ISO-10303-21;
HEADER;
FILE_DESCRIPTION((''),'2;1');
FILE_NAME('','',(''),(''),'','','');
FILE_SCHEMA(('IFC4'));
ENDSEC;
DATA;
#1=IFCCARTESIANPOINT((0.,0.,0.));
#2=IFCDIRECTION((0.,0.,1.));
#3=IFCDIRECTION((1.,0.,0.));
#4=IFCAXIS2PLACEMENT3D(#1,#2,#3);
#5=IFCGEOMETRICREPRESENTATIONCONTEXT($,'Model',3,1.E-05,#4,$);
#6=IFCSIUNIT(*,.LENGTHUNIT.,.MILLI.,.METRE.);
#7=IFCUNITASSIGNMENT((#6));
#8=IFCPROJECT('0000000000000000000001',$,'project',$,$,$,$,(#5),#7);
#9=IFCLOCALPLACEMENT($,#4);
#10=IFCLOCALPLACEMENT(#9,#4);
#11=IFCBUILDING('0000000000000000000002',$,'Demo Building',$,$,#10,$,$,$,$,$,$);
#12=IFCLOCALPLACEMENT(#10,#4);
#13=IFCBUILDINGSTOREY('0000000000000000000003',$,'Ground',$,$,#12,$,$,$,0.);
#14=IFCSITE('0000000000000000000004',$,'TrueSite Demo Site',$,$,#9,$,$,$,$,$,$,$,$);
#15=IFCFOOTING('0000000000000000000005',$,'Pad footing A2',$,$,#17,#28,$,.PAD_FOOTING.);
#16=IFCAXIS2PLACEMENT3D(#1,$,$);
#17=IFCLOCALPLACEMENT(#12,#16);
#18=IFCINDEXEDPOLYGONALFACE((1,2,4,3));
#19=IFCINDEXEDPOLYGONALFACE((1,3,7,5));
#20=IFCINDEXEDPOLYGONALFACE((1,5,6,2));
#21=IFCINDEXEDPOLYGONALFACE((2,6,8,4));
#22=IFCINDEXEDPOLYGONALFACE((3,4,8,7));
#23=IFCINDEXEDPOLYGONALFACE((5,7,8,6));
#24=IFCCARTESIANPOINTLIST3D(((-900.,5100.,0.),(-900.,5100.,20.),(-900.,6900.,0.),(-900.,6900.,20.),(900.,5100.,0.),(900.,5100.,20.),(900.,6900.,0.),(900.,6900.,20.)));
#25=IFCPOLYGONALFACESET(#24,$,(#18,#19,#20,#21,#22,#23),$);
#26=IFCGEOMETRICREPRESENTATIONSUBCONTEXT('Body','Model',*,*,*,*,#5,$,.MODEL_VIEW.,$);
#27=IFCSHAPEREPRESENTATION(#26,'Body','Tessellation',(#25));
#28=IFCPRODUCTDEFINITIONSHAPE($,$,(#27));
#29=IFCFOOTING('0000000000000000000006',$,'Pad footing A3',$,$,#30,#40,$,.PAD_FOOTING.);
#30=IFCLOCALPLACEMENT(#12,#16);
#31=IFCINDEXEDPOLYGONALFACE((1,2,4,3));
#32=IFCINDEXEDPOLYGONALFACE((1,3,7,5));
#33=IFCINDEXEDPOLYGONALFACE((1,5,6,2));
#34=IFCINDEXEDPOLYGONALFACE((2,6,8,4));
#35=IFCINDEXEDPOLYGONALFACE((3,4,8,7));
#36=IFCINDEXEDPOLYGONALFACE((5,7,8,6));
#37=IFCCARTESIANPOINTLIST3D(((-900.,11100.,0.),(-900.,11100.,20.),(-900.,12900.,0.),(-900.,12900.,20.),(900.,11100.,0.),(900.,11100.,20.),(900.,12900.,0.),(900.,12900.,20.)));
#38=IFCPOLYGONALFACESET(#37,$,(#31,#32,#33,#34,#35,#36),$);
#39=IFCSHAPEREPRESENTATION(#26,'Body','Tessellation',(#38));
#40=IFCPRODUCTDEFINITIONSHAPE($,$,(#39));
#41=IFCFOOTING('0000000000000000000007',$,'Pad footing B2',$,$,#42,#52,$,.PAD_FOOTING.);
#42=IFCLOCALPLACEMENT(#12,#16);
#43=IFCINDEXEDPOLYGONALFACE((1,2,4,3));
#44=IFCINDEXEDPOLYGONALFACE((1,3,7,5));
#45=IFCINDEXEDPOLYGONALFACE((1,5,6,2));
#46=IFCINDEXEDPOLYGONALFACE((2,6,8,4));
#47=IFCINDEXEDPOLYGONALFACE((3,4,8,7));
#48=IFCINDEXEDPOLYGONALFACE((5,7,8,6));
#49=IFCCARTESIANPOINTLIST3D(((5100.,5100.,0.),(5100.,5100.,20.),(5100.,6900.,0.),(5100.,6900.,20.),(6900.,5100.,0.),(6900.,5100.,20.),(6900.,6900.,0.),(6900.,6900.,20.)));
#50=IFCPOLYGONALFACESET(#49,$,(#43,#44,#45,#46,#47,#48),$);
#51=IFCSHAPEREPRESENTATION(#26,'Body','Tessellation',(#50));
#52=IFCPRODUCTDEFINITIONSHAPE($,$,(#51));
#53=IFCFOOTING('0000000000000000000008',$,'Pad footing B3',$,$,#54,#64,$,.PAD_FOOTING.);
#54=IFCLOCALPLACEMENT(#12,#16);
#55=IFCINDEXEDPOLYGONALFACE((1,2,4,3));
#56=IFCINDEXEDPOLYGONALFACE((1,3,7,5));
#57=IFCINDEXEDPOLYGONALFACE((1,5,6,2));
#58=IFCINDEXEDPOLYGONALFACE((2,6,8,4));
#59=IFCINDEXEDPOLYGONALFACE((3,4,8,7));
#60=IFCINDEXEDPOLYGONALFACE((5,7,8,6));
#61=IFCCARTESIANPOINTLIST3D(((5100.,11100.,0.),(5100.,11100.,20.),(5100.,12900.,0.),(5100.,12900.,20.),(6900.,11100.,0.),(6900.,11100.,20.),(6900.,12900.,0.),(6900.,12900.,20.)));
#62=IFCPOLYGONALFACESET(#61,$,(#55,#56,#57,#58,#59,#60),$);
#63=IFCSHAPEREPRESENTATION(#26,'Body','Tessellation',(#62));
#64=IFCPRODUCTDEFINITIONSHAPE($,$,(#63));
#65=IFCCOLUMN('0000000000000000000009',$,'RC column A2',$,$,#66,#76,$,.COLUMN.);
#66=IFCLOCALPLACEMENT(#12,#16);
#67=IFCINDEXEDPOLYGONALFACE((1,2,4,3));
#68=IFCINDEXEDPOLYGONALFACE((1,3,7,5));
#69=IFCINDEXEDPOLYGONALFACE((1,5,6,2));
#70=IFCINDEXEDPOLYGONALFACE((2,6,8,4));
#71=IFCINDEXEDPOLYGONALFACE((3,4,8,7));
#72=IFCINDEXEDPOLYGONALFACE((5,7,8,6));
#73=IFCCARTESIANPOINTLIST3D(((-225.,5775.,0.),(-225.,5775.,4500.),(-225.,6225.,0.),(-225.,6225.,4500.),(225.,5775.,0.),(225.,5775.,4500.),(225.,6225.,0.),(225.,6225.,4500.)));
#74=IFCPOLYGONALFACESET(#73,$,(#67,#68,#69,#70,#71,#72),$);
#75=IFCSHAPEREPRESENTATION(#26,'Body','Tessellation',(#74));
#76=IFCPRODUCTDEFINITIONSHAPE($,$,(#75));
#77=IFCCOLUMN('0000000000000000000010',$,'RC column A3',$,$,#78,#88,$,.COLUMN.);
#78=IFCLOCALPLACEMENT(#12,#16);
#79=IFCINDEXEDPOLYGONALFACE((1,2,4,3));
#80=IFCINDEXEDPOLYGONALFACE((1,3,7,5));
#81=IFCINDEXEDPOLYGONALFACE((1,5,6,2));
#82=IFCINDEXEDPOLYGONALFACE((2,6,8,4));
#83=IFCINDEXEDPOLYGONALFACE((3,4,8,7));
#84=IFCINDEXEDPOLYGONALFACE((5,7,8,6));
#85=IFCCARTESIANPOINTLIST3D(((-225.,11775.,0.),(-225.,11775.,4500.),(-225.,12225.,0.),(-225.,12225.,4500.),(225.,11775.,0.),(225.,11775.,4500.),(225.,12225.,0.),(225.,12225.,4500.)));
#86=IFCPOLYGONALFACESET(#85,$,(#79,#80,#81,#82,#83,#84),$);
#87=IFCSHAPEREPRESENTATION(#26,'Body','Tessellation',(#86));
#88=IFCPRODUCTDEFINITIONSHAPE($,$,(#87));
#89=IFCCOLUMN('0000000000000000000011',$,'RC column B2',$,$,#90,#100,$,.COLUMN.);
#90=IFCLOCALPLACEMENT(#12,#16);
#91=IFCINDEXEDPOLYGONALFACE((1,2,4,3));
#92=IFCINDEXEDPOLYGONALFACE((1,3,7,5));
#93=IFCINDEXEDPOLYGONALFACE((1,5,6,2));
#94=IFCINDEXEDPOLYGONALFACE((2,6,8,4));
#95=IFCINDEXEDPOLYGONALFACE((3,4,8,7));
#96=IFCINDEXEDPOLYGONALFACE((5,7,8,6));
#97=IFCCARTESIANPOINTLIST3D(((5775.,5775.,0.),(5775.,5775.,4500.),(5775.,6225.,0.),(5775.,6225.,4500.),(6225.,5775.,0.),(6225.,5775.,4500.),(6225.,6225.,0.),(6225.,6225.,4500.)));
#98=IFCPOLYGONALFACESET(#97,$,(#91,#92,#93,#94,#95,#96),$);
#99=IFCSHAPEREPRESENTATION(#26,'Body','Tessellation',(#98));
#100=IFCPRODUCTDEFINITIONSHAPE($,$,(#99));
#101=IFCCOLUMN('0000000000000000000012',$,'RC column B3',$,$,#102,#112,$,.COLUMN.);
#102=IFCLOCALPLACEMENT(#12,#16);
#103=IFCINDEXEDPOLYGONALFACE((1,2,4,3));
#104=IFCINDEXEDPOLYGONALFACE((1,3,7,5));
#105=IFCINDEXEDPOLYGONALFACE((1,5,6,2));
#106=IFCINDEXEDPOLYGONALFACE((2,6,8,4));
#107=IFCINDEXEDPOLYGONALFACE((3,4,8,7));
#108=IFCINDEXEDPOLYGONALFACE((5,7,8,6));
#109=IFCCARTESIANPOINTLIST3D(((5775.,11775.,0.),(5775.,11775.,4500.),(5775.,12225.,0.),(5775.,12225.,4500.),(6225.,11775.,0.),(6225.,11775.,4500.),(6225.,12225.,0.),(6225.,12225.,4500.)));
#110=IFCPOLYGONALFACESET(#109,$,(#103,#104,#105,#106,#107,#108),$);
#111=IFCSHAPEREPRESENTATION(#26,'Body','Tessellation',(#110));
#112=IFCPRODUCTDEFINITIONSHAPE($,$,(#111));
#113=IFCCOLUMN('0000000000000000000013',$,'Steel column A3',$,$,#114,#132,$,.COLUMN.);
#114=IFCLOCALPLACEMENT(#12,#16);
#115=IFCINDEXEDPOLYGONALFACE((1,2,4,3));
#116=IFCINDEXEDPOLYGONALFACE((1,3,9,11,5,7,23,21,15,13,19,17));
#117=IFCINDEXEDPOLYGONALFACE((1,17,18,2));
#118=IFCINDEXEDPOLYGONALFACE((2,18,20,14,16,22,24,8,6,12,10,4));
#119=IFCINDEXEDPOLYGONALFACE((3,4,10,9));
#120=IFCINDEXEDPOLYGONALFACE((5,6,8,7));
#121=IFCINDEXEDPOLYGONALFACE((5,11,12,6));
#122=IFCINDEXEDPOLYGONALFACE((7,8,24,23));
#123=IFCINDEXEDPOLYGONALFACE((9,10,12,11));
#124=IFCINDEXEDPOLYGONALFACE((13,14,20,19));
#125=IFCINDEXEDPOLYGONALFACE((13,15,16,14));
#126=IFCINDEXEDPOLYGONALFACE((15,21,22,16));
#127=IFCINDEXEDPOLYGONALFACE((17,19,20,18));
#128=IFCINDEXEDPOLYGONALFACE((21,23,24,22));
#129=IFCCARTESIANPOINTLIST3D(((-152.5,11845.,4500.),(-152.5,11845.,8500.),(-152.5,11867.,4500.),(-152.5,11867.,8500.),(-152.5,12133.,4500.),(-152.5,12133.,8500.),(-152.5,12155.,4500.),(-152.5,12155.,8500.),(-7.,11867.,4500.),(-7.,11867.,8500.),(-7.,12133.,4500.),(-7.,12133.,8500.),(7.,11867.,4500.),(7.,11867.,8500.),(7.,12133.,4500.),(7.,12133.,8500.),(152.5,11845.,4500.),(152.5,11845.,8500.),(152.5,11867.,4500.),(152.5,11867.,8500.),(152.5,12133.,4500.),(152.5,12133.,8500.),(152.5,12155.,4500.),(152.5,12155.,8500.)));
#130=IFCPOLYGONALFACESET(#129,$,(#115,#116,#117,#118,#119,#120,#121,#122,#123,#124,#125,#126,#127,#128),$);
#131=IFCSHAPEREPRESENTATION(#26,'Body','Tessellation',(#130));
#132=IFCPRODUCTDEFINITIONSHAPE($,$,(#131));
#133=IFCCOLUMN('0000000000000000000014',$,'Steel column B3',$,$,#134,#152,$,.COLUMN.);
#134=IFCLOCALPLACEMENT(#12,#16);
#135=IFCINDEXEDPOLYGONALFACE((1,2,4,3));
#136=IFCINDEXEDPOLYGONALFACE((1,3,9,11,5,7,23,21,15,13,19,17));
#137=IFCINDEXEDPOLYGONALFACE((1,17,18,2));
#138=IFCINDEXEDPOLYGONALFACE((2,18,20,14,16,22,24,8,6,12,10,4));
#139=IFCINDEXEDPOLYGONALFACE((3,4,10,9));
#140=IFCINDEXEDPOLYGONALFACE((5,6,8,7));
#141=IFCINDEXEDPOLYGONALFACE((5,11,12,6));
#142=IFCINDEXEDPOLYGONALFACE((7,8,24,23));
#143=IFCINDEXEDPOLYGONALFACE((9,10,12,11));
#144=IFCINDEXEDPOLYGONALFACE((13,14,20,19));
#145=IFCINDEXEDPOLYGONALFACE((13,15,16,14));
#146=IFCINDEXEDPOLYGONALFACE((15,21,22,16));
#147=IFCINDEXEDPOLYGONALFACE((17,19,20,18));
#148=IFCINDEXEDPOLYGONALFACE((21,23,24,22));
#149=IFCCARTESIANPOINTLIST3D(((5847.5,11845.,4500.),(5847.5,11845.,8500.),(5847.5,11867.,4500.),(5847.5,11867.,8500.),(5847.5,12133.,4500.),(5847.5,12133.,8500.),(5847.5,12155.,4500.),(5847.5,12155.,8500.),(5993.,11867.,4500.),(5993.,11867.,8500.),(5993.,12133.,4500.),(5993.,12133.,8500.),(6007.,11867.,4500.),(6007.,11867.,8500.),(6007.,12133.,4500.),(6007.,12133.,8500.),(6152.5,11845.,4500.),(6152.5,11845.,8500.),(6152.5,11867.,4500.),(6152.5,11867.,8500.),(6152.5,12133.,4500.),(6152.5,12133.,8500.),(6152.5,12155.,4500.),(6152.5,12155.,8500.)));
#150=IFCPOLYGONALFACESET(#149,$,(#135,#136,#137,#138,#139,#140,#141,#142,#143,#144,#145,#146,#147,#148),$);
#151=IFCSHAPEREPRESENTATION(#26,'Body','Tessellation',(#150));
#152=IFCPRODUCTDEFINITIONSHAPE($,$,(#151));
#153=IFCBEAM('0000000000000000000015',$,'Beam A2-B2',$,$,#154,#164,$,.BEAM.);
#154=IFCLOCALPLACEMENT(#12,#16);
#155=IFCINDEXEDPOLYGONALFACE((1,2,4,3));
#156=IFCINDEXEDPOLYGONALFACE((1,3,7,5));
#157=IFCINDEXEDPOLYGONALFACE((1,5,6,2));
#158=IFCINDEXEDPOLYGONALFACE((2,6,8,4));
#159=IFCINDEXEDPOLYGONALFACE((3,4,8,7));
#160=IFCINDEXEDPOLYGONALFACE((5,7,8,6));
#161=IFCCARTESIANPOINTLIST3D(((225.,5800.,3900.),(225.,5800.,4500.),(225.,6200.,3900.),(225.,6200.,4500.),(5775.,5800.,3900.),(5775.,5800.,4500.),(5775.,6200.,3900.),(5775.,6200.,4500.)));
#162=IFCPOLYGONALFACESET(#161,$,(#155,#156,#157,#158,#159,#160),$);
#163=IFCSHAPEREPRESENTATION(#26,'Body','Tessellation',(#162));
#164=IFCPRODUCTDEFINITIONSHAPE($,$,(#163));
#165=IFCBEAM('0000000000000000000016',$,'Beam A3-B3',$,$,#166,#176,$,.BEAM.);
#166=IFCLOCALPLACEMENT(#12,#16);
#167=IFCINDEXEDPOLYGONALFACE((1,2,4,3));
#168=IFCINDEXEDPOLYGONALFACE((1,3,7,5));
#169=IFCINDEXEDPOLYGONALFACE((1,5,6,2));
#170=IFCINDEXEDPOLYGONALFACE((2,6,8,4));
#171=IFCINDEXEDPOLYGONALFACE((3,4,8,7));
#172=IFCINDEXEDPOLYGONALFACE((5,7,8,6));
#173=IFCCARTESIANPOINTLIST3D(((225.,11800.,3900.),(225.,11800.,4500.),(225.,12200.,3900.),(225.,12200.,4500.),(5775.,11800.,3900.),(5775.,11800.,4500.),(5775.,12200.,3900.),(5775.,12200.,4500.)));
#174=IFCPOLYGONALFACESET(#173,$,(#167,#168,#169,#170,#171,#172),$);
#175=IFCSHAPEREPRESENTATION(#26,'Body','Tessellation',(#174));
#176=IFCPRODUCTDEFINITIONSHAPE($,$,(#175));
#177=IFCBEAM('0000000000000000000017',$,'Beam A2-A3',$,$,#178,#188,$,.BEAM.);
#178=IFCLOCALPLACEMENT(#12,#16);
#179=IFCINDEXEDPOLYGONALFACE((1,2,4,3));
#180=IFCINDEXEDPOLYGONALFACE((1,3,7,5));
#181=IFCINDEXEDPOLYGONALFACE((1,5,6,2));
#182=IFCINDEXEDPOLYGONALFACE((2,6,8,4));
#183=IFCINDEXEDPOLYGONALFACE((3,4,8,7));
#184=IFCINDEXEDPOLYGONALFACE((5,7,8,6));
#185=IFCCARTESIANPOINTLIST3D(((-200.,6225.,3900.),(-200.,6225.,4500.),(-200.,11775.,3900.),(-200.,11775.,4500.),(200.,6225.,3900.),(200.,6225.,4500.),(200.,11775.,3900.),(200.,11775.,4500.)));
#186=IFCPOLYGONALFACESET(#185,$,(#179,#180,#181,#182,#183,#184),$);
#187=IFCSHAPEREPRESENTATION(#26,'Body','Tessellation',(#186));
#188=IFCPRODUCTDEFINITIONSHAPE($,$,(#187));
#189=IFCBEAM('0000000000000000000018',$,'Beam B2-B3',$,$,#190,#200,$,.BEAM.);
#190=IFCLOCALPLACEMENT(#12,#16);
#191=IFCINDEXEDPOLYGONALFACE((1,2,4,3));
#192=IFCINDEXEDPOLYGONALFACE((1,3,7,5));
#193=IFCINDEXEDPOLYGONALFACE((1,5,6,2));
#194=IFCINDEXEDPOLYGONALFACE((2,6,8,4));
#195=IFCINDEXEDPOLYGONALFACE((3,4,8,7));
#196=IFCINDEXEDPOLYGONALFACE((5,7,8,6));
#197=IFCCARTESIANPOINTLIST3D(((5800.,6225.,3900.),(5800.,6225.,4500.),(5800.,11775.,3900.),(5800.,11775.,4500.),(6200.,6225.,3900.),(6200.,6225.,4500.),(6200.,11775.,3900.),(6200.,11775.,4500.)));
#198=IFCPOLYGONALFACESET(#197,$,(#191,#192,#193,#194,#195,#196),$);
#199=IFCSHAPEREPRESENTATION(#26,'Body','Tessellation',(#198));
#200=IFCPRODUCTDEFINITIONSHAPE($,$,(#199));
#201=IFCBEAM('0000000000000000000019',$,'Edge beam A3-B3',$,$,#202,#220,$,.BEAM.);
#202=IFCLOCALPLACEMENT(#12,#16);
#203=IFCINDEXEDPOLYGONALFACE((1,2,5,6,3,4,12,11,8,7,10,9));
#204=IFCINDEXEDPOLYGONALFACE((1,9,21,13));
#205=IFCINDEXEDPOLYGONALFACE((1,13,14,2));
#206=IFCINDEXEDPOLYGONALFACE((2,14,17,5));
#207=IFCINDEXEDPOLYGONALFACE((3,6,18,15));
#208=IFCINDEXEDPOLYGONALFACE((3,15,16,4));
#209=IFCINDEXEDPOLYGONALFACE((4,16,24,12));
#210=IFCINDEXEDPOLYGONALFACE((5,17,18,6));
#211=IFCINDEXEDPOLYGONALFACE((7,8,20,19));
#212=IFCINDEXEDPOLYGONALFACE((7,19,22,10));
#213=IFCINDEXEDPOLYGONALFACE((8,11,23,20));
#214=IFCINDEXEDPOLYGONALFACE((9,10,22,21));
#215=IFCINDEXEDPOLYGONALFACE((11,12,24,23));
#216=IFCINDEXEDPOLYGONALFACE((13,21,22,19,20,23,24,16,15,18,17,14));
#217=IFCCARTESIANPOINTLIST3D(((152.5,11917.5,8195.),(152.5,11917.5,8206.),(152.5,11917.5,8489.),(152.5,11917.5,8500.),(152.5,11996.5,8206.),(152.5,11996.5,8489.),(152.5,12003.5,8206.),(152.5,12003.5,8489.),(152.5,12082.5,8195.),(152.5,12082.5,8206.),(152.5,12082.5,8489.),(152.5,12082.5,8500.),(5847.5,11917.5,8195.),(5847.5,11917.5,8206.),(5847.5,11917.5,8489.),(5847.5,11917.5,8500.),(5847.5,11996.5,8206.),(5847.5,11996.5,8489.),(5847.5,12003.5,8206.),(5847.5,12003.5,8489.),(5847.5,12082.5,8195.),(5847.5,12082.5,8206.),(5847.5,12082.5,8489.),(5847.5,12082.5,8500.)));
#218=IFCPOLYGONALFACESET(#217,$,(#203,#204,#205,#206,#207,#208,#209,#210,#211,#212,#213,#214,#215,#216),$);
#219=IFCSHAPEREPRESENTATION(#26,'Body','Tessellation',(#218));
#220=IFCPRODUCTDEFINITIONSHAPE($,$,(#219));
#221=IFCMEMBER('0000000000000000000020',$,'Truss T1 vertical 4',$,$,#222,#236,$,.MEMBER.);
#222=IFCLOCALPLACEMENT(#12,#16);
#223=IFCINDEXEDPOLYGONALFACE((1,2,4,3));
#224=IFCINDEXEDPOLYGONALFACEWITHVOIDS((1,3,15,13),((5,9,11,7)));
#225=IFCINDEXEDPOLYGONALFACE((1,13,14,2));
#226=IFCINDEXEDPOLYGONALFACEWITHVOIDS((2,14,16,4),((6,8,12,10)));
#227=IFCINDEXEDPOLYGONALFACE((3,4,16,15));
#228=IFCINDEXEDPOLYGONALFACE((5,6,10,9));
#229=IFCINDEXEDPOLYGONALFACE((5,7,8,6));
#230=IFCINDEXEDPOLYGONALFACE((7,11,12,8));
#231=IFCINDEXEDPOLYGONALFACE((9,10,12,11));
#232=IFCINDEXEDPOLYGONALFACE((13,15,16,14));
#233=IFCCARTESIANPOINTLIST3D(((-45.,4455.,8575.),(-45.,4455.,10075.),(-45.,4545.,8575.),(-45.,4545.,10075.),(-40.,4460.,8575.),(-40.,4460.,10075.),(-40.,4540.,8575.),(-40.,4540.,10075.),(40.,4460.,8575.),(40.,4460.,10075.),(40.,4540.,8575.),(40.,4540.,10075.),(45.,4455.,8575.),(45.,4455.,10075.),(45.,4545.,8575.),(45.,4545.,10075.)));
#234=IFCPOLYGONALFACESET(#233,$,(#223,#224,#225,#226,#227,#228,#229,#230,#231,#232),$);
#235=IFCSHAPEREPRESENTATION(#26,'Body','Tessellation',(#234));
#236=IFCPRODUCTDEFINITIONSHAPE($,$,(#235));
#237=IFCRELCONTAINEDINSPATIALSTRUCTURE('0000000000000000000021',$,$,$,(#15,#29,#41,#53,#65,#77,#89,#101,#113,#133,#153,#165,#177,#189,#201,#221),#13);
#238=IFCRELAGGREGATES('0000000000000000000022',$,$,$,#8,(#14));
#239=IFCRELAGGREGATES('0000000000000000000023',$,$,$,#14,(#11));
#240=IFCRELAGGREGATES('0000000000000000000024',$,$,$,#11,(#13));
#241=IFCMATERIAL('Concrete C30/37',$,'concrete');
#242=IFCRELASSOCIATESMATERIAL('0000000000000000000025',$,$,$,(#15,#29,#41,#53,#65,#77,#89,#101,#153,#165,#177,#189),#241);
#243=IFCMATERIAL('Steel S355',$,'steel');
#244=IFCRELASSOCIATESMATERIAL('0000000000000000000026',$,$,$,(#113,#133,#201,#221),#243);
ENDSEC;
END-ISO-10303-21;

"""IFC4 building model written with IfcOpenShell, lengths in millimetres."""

from ifc_helpers import new_model, si_unit, frame, origin_with_axes, place, context, subcontext, project, spatial, rectangle, hollow_rectangle, i_section, extrude, material, element, save


model = new_model("IFC4")

# Units and contexts
model_context = context("Model", 3, precision=1e-05, world=origin_with_axes())
body_context = subcontext(model_context, "Body", "Model", "MODEL_VIEW")
ifc_project = project(units=[si_unit("LENGTHUNIT", "METRE", prefix="MILLI")], contexts=[model_context])

# Site, building, storey
site_placement = place(None, origin_with_axes())
site = spatial("IfcSite", under=ifc_project, at=site_placement, Name="TrueSite Demo Site")
building_placement = place(site_placement, origin_with_axes())
building = spatial("IfcBuilding", under=site, at=building_placement, Name="Demo Building")
storey_placement = place(building_placement, origin_with_axes())
storey = spatial("IfcBuildingStorey", under=building, at=storey_placement, Name="Ground", Elevation=0.0)

# Footings
ifc_material_1 = material(Name="Concrete C30/37", Category="concrete")
for number, where, z_axis, x_axis, name in (
    (1, (0.0, 6000.0, 0.0), (0.0, 0.0, 1.0), (1.0, 0.0, 0.0), "Pad footing A2"),
    (2, (0.0, 12000.0, 0.0), (0.0, 0.0, 1.0), (1.0, 0.0, 0.0), "Pad footing A3"),
    (3, (6000.0, 6000.0, 0.0), (0.0, 0.0, 1.0), (1.0, 0.0, 0.0), "Pad footing B2"),
    (4, (6000.0, 12000.0, 0.0), (0.0, 0.0, 1.0), (1.0, 0.0, 0.0), "Pad footing B3"),
):
    element("IfcFooting", number, at=place(storey_placement, frame(where, z_axis=z_axis, x_axis=x_axis)), inside=storey, material=ifc_material_1, Name=name, PredefinedType="PAD_FOOTING", context=body_context, shape_type="SweptSolid", body=[
        extrude(rectangle(XDim=1800.0, YDim=1800.0), origin_with_axes(), (0.0, 0.0, 1.0), 20.0),
    ])

# Columns
for number, where, z_axis, x_axis, name in (
    (5, (0.0, 6000.0, 0.0), (0.0, 0.0, 1.0), (1.0, 0.0, 0.0), "RC column A2"),
    (6, (0.0, 12000.0, 0.0), (0.0, 0.0, 1.0), (1.0, 0.0, 0.0), "RC column A3"),
    (7, (6000.0, 6000.0, 0.0), (0.0, 0.0, 1.0), (1.0, 0.0, 0.0), "RC column B2"),
    (8, (6000.0, 12000.0, 0.0), (0.0, 0.0, 1.0), (1.0, 0.0, 0.0), "RC column B3"),
):
    element("IfcColumn", number, at=place(storey_placement, frame(where, z_axis=z_axis, x_axis=x_axis)), inside=storey, material=ifc_material_1, Name=name, PredefinedType="COLUMN", context=body_context, shape_type="SweptSolid", body=[
        extrude(rectangle(XDim=450.0, YDim=450.0), origin_with_axes(), (0.0, 0.0, 1.0), 4500.0),
    ])
ifc_material_2 = material(Name="Steel S355", Category="steel")
for number, where, z_axis, x_axis, name in (
    (9, (0.0, 12000.0, 4500.0), (0.0, 0.0, 1.0), (1.0, 0.0, 0.0), "Steel column A3"),
    (10, (6000.0, 12000.0, 4500.0), (0.0, 0.0, 1.0), (1.0, 0.0, 0.0), "Steel column B3"),
):
    element("IfcColumn", number, at=place(storey_placement, frame(where, z_axis=z_axis, x_axis=x_axis)), inside=storey, material=ifc_material_2, Name=name, PredefinedType="COLUMN", context=body_context, shape_type="SweptSolid", body=[
        extrude(i_section(OverallWidth=305.0, OverallDepth=310.0, WebThickness=14.0, FlangeThickness=22.0), origin_with_axes(), (0.0, 0.0, 1.0), 4000.0),
    ])

# Beams
for number, where, z_axis, x_axis, name in (
    (11, (225.0, 6000.0, 4200.0), (1.0, 0.0, 0.0), (0.0, 1.0, 0.0), "Beam A2-B2"),
    (12, (225.0, 12000.0, 4200.0), (1.0, 0.0, 0.0), (0.0, 1.0, 0.0), "Beam A3-B3"),
    (13, (0.0, 6225.0, 4200.0), (0.0, 1.0, 0.0), (-1.0, 0.0, 0.0), "Beam A2-A3"),
    (14, (6000.0, 6225.0, 4200.0), (0.0, 1.0, 0.0), (-1.0, 0.0, 0.0), "Beam B2-B3"),
):
    element("IfcBeam", number, at=place(storey_placement, frame(where, z_axis=z_axis, x_axis=x_axis)), inside=storey, material=ifc_material_1, Name=name, PredefinedType="BEAM", context=body_context, shape_type="SweptSolid", body=[
        extrude(rectangle(XDim=400.0, YDim=600.0), origin_with_axes(), (0.0, 0.0, 1.0), 5550.0),
    ])
beam_placement = place(storey_placement, frame((152.5, 12000.0, 8347.5), z_axis=(1.0, 0.0, 0.0), x_axis=(0.0, 1.0, 0.0)))
element("IfcBeam", 15, at=beam_placement, inside=storey, material=ifc_material_2, Name="Edge beam A3-B3", PredefinedType="BEAM", context=body_context, shape_type="SweptSolid", body=[
    extrude(i_section(OverallWidth=165.0, OverallDepth=305.0, WebThickness=7.0, FlangeThickness=11.0), origin_with_axes(), (0.0, 0.0, 1.0), 5695.0),
])

# Member
member_1_placement = place(storey_placement, frame((0.0, 4500.0, 8575.0), z_axis=(0.0, 0.0, 1.0), x_axis=(1.0, 0.0, 0.0)))
element("IfcMember", 16, at=member_1_placement, inside=storey, material=ifc_material_2, Name="Truss T1 vertical 4", PredefinedType="MEMBER", context=body_context, shape_type="SweptSolid", body=[
    extrude(hollow_rectangle(XDim=90.0, YDim=90.0, WallThickness=5.0), origin_with_axes(), (0.0, 0.0, 1.0), 1500.0),
])

save(model, "model.ifc")
